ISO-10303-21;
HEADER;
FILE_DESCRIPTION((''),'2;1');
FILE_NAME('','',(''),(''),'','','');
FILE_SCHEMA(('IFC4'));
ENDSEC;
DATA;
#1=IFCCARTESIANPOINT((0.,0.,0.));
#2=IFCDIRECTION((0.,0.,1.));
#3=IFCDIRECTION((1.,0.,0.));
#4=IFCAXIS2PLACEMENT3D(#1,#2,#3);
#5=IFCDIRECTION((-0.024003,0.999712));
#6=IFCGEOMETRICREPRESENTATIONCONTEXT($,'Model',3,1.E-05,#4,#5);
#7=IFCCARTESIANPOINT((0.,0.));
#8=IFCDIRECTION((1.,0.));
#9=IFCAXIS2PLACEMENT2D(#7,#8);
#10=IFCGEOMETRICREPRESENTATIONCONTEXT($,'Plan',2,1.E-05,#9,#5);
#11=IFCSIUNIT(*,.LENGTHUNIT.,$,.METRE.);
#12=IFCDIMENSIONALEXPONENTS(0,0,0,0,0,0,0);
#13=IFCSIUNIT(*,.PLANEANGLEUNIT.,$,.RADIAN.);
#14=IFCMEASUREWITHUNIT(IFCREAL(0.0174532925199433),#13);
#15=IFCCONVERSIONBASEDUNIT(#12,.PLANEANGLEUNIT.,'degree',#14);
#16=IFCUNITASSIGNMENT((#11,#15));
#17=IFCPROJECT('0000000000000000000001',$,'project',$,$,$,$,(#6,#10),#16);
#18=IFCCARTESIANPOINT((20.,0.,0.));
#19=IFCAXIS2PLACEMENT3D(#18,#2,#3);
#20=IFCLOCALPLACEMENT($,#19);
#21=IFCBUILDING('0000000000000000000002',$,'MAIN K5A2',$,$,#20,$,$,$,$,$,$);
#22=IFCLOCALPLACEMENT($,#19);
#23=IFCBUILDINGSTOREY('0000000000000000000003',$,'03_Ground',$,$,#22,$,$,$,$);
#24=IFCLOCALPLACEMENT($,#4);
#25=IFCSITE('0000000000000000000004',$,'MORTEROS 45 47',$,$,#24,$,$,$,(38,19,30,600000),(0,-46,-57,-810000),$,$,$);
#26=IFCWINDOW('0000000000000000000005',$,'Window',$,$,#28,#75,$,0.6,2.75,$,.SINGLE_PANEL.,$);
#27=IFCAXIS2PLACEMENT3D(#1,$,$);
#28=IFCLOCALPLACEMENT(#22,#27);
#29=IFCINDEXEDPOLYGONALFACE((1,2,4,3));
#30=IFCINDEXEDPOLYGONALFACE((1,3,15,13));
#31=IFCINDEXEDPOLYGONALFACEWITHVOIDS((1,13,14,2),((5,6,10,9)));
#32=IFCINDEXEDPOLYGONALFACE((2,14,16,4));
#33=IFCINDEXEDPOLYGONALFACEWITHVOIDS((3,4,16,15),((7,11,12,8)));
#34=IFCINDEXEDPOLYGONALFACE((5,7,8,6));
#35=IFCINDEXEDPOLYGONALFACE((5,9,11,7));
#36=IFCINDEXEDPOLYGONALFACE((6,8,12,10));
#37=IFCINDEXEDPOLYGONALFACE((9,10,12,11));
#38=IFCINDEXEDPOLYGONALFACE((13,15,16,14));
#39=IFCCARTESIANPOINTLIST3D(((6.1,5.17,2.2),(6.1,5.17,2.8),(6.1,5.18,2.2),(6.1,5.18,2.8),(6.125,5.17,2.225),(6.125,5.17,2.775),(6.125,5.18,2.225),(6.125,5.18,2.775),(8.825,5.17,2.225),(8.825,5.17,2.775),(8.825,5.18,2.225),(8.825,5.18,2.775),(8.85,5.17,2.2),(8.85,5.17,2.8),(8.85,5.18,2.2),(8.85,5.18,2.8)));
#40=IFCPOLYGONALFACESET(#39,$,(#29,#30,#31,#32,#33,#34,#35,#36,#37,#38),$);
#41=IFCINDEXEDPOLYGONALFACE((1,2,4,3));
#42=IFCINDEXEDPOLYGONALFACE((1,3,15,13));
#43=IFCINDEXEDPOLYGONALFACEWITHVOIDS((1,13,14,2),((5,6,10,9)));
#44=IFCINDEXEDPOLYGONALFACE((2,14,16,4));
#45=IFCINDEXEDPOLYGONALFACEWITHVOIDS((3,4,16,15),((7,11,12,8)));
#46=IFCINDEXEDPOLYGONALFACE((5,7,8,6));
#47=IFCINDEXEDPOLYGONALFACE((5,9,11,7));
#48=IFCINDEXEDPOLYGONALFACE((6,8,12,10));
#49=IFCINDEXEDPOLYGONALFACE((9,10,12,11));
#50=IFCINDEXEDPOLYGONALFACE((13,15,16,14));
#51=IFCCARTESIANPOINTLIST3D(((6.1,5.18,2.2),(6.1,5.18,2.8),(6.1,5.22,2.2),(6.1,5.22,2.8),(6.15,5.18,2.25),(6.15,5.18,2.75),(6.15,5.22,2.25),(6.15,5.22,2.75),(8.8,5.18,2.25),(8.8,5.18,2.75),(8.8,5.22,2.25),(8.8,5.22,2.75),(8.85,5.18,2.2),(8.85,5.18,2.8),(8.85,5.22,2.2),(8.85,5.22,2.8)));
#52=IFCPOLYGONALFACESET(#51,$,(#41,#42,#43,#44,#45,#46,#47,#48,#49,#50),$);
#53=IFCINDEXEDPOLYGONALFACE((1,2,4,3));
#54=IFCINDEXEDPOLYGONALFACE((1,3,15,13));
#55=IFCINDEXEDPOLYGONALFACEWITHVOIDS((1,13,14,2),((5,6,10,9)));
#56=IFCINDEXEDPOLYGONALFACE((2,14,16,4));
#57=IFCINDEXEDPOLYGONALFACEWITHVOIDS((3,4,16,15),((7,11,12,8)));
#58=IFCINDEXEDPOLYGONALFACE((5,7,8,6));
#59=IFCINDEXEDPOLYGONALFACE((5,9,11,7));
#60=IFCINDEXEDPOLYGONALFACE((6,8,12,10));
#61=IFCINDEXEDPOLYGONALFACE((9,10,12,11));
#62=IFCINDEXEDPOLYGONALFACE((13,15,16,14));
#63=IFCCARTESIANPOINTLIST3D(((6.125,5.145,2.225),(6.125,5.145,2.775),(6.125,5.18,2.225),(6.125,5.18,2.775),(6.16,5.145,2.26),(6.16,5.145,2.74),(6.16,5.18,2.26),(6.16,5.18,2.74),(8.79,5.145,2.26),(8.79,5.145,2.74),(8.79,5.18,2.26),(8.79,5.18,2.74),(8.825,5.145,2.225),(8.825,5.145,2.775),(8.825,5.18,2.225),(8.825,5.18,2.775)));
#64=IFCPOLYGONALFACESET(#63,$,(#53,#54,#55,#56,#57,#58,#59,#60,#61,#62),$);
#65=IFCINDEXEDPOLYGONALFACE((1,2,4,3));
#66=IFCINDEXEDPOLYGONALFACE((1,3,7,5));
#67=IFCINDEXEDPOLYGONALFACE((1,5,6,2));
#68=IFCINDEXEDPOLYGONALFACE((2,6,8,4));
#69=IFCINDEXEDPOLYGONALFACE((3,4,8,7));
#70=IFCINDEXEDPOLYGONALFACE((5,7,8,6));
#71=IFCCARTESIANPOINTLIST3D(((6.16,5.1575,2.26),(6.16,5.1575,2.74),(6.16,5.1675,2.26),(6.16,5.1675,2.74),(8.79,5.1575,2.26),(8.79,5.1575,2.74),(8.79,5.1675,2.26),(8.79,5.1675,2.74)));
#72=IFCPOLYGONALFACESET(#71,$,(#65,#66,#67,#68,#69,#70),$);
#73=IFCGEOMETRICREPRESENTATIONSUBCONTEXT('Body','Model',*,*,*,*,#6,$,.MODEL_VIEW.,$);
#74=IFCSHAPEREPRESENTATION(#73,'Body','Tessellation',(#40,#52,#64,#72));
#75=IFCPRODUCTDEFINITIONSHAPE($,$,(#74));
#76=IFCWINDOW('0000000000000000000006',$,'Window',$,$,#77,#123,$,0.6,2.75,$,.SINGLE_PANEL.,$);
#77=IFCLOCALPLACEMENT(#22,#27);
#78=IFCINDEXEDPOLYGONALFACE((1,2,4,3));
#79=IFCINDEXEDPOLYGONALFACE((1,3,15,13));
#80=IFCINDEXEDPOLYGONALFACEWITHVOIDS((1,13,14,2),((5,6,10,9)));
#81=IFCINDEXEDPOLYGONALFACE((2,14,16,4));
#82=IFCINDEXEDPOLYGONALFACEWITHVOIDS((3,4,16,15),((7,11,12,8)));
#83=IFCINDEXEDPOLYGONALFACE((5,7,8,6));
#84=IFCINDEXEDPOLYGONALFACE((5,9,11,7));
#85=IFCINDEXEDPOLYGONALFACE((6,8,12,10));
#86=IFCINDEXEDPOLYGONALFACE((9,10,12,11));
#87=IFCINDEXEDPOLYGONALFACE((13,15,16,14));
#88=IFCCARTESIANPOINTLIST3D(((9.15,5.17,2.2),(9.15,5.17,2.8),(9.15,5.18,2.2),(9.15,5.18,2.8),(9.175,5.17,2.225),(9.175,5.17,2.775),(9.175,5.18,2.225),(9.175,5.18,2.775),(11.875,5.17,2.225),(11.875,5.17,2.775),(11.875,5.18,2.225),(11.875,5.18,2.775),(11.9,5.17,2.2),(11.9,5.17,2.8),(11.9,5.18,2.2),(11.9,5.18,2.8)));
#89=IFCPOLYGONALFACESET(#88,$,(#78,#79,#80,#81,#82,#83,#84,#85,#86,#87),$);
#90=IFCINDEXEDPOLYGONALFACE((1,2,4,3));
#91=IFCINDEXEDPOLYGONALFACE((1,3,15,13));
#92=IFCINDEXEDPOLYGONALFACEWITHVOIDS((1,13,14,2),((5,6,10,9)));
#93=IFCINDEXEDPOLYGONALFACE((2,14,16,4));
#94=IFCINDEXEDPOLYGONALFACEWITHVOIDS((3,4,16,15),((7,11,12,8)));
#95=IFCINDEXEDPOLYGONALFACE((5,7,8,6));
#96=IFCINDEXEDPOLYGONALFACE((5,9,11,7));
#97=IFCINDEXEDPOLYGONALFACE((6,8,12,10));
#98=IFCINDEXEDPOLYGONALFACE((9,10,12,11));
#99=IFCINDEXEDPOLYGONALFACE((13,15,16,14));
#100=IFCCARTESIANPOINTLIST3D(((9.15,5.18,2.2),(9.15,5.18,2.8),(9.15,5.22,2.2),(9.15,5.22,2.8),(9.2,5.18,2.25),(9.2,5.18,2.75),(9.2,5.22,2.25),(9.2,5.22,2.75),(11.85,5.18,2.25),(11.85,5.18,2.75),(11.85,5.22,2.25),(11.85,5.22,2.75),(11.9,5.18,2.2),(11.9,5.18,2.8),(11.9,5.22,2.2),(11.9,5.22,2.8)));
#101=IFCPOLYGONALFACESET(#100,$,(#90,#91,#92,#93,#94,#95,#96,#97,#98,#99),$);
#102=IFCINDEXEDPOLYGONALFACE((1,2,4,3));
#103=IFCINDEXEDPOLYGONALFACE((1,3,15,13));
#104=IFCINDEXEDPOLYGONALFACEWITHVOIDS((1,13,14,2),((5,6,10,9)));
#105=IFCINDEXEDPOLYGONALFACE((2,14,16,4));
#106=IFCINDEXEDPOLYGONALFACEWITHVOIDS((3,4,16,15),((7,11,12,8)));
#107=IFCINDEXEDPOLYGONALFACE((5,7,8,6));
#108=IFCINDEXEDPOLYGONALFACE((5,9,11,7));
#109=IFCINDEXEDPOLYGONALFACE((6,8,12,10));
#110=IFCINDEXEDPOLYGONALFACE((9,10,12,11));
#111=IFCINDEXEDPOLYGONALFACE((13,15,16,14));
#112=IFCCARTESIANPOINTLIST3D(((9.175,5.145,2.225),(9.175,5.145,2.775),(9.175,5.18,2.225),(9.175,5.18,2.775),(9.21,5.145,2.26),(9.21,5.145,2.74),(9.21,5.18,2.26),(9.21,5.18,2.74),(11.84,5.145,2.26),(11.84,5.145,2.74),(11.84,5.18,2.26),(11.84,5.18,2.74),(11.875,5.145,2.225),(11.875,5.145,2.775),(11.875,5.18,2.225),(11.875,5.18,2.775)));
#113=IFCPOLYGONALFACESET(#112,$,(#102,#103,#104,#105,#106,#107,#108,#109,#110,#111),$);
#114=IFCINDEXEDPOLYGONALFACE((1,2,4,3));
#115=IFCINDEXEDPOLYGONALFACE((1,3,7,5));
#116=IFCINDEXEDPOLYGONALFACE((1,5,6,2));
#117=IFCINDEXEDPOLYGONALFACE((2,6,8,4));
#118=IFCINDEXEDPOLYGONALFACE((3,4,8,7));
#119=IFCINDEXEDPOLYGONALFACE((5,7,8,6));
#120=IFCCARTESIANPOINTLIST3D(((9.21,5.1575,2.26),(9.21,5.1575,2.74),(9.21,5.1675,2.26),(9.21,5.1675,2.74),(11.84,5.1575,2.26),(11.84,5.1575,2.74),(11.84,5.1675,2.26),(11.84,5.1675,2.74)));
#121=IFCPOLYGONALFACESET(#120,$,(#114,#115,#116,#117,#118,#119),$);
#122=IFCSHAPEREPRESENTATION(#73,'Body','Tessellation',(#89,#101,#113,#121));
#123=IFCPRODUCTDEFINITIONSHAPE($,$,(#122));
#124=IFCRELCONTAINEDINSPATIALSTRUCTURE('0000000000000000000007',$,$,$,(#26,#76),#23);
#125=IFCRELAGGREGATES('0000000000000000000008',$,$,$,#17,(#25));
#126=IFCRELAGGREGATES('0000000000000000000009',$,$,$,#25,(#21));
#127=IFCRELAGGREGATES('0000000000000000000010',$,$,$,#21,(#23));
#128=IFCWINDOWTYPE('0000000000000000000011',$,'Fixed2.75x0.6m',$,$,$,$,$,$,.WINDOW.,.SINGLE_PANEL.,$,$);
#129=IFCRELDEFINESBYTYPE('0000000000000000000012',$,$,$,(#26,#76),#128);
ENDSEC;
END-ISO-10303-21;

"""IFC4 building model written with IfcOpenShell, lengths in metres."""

from ifc_helpers import new_model, entity, si_unit, converted_unit, direction, frame, origin_with_axes, origin_2d_with_axis, place, context, subcontext, project, spatial, line, indexed_curve, outline, extrude, shape, source, transform, mapped, type_object, element, save


model = new_model("IFC4")

# Units and contexts
model_context = context("Model", 3, precision=1e-05, world=origin_with_axes(), true_north=direction((-0.024003, 0.999712)))
plan_context = context("Plan", 2, precision=1e-05, world=origin_2d_with_axis(), true_north=direction((-0.024003, 0.999712)))
body_context_1 = subcontext(model_context, "Body", "Model", "MODEL_VIEW")
body_context_2 = subcontext(plan_context, "Body", "Plan", "PLAN_VIEW")
ifc_project = project(units=[si_unit("LENGTHUNIT", "METRE"), converted_unit("PLANEANGLEUNIT", "degree", entity("IfcReal", 0.0174532925199433), si_unit("PLANEANGLEUNIT", "RADIAN"), dimensions=[0, 0, 0, 0, 0, 0, 0])], contexts=[model_context, plan_context])

# Site, building, storey
site_placement = place(None, origin_with_axes())
site = spatial("IfcSite", under=ifc_project, at=site_placement, Name="MORTEROS 45 47", RefLatitude=(38, 19, 30, 600000), RefLongitude=(0, -46, -57, -810000))
building_placement = place(None, frame((20.0, 0.0, 0.0), z_axis=(0.0, 0.0, 1.0), x_axis=(1.0, 0.0, 0.0)))
building = spatial("IfcBuilding", under=site, at=building_placement, Name="MAIN K5A2")
storey_placement = place(None, frame((20.0, 0.0, 0.0), z_axis=(0.0, 0.0, 1.0), x_axis=(1.0, 0.0, 0.0)))
storey = spatial("IfcBuildingStorey", under=building, at=storey_placement, Name="03_Ground")

# Windows
window_type_1 = type_object("IfcWindowType", Name="Fixed2.75x0.6m", PartitioningType="SINGLE_PANEL", PredefinedType="WINDOW")
shared_shape_1 = source(origin_with_axes(), body_context_1, "Body", "SolidModel", [
    extrude(outline(indexed_curve([(0.0, 0.0), (2.75, 0.0), (2.75, 0.6), (0.0, 0.6)], segments=[line(1, 2, 3, 4, 1)]), holes=[indexed_curve([(0.025, 0.025), (2.725, 0.025), (2.725, 0.575), (0.025, 0.575)], segments=[line(1, 2, 3, 4, 1)])]), frame((0.0, 0.09, 0.0), z_axis=(0.0, -1.0, 0.0), x_axis=(1.0, 0.0, 0.0)), (0.0, 0.0, -1.0), 0.01),
    extrude(outline(indexed_curve([(0.0, 0.0), (2.75, 0.0), (2.75, 0.6), (0.0, 0.6)], segments=[line(1, 2, 3, 4, 1)]), holes=[indexed_curve([(0.05, 0.05), (2.7, 0.05), (2.7, 0.55), (0.05, 0.55)], segments=[line(1, 2, 3, 4, 1)])]), frame((0.0, 0.05, 0.0), z_axis=(0.0, -1.0, 0.0), x_axis=(1.0, 0.0, 0.0)), (0.0, 0.0, -1.0), 0.04),
    extrude(outline(indexed_curve([(0.0, 0.0), (2.7, 0.0), (2.7, 0.55), (0.0, 0.55)], segments=[line(1, 2, 3, 4, 1)]), holes=[indexed_curve([(0.035, 0.035), (2.665, 0.035), (2.665, 0.515), (0.035, 0.515)], segments=[line(1, 2, 3, 4, 1)])]), frame((0.025, 0.09, 0.025), z_axis=(0.0, -1.0, 0.0), x_axis=(1.0, 0.0, 0.0)), (0.0, 0.0, -1.0), 0.035),
    extrude(outline(indexed_curve([(0.035, 0.035), (2.665, 0.035), (2.665, 0.515), (0.035, 0.515)], segments=[line(1, 2, 3, 4, 1)])), frame((0.025, 0.1025, 0.025), z_axis=(0.0, -1.0, 0.0), x_axis=(1.0, 0.0, 0.0)), (0.0, 0.0, -1.0), 0.01),
])
shared_shape_2 = source(origin_with_axes(), body_context_2, "Body", "Curve2D", [
    entity("IfcIndexedPolyCurve", entity("IfcCartesianPointList2D", [[0.05, 0.05], [2.7, 0.05]])),
    entity("IfcIndexedPolyCurve", entity("IfcCartesianPointList2D", [[0.0, 0.1], [0.025, 0.1], [0.025, 0.09], [0.05, 0.09], [0.05, 0.05], [0.0, 0.05]]), [entity("IfcLineIndex", [1, 2, 3, 4, 5, 6, 1])]),
    entity("IfcIndexedPolyCurve", entity("IfcCartesianPointList2D", [[2.75, 0.1], [2.725, 0.1], [2.725, 0.09], [2.7, 0.09], [2.7, 0.05], [2.75, 0.05]]), [entity("IfcLineIndex", [1, 2, 3, 4, 5, 6, 1])]),
    entity("IfcIndexedPolyCurve", entity("IfcCartesianPointList2D", [[0.025, 0.09], [0.06, 0.09], [0.06, 0.125], [0.025, 0.125]]), [entity("IfcLineIndex", [1, 2, 3, 4, 1])]),
    entity("IfcIndexedPolyCurve", entity("IfcCartesianPointList2D", [[2.725, 0.09], [2.69, 0.09], [2.69, 0.125], [2.725, 0.125]]), [entity("IfcLineIndex", [1, 2, 3, 4, 1])]),
    entity("IfcIndexedPolyCurve", entity("IfcCartesianPointList2D", [[0.06, 0.09], [2.69, 0.09]])),
    entity("IfcIndexedPolyCurve", entity("IfcCartesianPointList2D", [[0.06, 0.125], [2.69, 0.125]])),
    entity("IfcIndexedPolyCurve", entity("IfcCartesianPointList2D", [[0.06, 0.1075], [2.69, 0.1075]])),
])
for number, where, z_axis, x_axis, name in (
    (1, (28.85, 5.27, 2.2), (0.0, 0.0, 1.0), (-1.0, 0.0, 0.0), "Window"),
    (2, (31.9, 5.27, 2.2), (0.0, 0.0, 1.0), (-1.0, 0.0, 0.0), "Window"),
):
    element("IfcWindow", number, at=place(None, frame(where, z_axis=z_axis, x_axis=x_axis)), inside=storey, type_object=window_type_1, Name=name, OverallHeight=0.6, OverallWidth=2.75, PartitioningType="SINGLE_PANEL", shapes=[
        shape(body_context_1, "Body", "MappedRepresentation", [mapped(shared_shape_1, transform((0.0, 0.0, 0.0), x_axis=(1.0, 0.0, 0.0), y_axis=(0.0, 1.0, 0.0), z_axis=(0.0, 0.0, 1.0), scale=1.0))]),
        shape(body_context_2, "Body", "MappedRepresentation", [mapped(shared_shape_2, transform((0.0, 0.0, 0.0), x_axis=(1.0, 0.0, 0.0), y_axis=(0.0, 1.0, 0.0), z_axis=(0.0, 0.0, 1.0), scale=1.0))]),
    ])

save(model, "model.ifc")
